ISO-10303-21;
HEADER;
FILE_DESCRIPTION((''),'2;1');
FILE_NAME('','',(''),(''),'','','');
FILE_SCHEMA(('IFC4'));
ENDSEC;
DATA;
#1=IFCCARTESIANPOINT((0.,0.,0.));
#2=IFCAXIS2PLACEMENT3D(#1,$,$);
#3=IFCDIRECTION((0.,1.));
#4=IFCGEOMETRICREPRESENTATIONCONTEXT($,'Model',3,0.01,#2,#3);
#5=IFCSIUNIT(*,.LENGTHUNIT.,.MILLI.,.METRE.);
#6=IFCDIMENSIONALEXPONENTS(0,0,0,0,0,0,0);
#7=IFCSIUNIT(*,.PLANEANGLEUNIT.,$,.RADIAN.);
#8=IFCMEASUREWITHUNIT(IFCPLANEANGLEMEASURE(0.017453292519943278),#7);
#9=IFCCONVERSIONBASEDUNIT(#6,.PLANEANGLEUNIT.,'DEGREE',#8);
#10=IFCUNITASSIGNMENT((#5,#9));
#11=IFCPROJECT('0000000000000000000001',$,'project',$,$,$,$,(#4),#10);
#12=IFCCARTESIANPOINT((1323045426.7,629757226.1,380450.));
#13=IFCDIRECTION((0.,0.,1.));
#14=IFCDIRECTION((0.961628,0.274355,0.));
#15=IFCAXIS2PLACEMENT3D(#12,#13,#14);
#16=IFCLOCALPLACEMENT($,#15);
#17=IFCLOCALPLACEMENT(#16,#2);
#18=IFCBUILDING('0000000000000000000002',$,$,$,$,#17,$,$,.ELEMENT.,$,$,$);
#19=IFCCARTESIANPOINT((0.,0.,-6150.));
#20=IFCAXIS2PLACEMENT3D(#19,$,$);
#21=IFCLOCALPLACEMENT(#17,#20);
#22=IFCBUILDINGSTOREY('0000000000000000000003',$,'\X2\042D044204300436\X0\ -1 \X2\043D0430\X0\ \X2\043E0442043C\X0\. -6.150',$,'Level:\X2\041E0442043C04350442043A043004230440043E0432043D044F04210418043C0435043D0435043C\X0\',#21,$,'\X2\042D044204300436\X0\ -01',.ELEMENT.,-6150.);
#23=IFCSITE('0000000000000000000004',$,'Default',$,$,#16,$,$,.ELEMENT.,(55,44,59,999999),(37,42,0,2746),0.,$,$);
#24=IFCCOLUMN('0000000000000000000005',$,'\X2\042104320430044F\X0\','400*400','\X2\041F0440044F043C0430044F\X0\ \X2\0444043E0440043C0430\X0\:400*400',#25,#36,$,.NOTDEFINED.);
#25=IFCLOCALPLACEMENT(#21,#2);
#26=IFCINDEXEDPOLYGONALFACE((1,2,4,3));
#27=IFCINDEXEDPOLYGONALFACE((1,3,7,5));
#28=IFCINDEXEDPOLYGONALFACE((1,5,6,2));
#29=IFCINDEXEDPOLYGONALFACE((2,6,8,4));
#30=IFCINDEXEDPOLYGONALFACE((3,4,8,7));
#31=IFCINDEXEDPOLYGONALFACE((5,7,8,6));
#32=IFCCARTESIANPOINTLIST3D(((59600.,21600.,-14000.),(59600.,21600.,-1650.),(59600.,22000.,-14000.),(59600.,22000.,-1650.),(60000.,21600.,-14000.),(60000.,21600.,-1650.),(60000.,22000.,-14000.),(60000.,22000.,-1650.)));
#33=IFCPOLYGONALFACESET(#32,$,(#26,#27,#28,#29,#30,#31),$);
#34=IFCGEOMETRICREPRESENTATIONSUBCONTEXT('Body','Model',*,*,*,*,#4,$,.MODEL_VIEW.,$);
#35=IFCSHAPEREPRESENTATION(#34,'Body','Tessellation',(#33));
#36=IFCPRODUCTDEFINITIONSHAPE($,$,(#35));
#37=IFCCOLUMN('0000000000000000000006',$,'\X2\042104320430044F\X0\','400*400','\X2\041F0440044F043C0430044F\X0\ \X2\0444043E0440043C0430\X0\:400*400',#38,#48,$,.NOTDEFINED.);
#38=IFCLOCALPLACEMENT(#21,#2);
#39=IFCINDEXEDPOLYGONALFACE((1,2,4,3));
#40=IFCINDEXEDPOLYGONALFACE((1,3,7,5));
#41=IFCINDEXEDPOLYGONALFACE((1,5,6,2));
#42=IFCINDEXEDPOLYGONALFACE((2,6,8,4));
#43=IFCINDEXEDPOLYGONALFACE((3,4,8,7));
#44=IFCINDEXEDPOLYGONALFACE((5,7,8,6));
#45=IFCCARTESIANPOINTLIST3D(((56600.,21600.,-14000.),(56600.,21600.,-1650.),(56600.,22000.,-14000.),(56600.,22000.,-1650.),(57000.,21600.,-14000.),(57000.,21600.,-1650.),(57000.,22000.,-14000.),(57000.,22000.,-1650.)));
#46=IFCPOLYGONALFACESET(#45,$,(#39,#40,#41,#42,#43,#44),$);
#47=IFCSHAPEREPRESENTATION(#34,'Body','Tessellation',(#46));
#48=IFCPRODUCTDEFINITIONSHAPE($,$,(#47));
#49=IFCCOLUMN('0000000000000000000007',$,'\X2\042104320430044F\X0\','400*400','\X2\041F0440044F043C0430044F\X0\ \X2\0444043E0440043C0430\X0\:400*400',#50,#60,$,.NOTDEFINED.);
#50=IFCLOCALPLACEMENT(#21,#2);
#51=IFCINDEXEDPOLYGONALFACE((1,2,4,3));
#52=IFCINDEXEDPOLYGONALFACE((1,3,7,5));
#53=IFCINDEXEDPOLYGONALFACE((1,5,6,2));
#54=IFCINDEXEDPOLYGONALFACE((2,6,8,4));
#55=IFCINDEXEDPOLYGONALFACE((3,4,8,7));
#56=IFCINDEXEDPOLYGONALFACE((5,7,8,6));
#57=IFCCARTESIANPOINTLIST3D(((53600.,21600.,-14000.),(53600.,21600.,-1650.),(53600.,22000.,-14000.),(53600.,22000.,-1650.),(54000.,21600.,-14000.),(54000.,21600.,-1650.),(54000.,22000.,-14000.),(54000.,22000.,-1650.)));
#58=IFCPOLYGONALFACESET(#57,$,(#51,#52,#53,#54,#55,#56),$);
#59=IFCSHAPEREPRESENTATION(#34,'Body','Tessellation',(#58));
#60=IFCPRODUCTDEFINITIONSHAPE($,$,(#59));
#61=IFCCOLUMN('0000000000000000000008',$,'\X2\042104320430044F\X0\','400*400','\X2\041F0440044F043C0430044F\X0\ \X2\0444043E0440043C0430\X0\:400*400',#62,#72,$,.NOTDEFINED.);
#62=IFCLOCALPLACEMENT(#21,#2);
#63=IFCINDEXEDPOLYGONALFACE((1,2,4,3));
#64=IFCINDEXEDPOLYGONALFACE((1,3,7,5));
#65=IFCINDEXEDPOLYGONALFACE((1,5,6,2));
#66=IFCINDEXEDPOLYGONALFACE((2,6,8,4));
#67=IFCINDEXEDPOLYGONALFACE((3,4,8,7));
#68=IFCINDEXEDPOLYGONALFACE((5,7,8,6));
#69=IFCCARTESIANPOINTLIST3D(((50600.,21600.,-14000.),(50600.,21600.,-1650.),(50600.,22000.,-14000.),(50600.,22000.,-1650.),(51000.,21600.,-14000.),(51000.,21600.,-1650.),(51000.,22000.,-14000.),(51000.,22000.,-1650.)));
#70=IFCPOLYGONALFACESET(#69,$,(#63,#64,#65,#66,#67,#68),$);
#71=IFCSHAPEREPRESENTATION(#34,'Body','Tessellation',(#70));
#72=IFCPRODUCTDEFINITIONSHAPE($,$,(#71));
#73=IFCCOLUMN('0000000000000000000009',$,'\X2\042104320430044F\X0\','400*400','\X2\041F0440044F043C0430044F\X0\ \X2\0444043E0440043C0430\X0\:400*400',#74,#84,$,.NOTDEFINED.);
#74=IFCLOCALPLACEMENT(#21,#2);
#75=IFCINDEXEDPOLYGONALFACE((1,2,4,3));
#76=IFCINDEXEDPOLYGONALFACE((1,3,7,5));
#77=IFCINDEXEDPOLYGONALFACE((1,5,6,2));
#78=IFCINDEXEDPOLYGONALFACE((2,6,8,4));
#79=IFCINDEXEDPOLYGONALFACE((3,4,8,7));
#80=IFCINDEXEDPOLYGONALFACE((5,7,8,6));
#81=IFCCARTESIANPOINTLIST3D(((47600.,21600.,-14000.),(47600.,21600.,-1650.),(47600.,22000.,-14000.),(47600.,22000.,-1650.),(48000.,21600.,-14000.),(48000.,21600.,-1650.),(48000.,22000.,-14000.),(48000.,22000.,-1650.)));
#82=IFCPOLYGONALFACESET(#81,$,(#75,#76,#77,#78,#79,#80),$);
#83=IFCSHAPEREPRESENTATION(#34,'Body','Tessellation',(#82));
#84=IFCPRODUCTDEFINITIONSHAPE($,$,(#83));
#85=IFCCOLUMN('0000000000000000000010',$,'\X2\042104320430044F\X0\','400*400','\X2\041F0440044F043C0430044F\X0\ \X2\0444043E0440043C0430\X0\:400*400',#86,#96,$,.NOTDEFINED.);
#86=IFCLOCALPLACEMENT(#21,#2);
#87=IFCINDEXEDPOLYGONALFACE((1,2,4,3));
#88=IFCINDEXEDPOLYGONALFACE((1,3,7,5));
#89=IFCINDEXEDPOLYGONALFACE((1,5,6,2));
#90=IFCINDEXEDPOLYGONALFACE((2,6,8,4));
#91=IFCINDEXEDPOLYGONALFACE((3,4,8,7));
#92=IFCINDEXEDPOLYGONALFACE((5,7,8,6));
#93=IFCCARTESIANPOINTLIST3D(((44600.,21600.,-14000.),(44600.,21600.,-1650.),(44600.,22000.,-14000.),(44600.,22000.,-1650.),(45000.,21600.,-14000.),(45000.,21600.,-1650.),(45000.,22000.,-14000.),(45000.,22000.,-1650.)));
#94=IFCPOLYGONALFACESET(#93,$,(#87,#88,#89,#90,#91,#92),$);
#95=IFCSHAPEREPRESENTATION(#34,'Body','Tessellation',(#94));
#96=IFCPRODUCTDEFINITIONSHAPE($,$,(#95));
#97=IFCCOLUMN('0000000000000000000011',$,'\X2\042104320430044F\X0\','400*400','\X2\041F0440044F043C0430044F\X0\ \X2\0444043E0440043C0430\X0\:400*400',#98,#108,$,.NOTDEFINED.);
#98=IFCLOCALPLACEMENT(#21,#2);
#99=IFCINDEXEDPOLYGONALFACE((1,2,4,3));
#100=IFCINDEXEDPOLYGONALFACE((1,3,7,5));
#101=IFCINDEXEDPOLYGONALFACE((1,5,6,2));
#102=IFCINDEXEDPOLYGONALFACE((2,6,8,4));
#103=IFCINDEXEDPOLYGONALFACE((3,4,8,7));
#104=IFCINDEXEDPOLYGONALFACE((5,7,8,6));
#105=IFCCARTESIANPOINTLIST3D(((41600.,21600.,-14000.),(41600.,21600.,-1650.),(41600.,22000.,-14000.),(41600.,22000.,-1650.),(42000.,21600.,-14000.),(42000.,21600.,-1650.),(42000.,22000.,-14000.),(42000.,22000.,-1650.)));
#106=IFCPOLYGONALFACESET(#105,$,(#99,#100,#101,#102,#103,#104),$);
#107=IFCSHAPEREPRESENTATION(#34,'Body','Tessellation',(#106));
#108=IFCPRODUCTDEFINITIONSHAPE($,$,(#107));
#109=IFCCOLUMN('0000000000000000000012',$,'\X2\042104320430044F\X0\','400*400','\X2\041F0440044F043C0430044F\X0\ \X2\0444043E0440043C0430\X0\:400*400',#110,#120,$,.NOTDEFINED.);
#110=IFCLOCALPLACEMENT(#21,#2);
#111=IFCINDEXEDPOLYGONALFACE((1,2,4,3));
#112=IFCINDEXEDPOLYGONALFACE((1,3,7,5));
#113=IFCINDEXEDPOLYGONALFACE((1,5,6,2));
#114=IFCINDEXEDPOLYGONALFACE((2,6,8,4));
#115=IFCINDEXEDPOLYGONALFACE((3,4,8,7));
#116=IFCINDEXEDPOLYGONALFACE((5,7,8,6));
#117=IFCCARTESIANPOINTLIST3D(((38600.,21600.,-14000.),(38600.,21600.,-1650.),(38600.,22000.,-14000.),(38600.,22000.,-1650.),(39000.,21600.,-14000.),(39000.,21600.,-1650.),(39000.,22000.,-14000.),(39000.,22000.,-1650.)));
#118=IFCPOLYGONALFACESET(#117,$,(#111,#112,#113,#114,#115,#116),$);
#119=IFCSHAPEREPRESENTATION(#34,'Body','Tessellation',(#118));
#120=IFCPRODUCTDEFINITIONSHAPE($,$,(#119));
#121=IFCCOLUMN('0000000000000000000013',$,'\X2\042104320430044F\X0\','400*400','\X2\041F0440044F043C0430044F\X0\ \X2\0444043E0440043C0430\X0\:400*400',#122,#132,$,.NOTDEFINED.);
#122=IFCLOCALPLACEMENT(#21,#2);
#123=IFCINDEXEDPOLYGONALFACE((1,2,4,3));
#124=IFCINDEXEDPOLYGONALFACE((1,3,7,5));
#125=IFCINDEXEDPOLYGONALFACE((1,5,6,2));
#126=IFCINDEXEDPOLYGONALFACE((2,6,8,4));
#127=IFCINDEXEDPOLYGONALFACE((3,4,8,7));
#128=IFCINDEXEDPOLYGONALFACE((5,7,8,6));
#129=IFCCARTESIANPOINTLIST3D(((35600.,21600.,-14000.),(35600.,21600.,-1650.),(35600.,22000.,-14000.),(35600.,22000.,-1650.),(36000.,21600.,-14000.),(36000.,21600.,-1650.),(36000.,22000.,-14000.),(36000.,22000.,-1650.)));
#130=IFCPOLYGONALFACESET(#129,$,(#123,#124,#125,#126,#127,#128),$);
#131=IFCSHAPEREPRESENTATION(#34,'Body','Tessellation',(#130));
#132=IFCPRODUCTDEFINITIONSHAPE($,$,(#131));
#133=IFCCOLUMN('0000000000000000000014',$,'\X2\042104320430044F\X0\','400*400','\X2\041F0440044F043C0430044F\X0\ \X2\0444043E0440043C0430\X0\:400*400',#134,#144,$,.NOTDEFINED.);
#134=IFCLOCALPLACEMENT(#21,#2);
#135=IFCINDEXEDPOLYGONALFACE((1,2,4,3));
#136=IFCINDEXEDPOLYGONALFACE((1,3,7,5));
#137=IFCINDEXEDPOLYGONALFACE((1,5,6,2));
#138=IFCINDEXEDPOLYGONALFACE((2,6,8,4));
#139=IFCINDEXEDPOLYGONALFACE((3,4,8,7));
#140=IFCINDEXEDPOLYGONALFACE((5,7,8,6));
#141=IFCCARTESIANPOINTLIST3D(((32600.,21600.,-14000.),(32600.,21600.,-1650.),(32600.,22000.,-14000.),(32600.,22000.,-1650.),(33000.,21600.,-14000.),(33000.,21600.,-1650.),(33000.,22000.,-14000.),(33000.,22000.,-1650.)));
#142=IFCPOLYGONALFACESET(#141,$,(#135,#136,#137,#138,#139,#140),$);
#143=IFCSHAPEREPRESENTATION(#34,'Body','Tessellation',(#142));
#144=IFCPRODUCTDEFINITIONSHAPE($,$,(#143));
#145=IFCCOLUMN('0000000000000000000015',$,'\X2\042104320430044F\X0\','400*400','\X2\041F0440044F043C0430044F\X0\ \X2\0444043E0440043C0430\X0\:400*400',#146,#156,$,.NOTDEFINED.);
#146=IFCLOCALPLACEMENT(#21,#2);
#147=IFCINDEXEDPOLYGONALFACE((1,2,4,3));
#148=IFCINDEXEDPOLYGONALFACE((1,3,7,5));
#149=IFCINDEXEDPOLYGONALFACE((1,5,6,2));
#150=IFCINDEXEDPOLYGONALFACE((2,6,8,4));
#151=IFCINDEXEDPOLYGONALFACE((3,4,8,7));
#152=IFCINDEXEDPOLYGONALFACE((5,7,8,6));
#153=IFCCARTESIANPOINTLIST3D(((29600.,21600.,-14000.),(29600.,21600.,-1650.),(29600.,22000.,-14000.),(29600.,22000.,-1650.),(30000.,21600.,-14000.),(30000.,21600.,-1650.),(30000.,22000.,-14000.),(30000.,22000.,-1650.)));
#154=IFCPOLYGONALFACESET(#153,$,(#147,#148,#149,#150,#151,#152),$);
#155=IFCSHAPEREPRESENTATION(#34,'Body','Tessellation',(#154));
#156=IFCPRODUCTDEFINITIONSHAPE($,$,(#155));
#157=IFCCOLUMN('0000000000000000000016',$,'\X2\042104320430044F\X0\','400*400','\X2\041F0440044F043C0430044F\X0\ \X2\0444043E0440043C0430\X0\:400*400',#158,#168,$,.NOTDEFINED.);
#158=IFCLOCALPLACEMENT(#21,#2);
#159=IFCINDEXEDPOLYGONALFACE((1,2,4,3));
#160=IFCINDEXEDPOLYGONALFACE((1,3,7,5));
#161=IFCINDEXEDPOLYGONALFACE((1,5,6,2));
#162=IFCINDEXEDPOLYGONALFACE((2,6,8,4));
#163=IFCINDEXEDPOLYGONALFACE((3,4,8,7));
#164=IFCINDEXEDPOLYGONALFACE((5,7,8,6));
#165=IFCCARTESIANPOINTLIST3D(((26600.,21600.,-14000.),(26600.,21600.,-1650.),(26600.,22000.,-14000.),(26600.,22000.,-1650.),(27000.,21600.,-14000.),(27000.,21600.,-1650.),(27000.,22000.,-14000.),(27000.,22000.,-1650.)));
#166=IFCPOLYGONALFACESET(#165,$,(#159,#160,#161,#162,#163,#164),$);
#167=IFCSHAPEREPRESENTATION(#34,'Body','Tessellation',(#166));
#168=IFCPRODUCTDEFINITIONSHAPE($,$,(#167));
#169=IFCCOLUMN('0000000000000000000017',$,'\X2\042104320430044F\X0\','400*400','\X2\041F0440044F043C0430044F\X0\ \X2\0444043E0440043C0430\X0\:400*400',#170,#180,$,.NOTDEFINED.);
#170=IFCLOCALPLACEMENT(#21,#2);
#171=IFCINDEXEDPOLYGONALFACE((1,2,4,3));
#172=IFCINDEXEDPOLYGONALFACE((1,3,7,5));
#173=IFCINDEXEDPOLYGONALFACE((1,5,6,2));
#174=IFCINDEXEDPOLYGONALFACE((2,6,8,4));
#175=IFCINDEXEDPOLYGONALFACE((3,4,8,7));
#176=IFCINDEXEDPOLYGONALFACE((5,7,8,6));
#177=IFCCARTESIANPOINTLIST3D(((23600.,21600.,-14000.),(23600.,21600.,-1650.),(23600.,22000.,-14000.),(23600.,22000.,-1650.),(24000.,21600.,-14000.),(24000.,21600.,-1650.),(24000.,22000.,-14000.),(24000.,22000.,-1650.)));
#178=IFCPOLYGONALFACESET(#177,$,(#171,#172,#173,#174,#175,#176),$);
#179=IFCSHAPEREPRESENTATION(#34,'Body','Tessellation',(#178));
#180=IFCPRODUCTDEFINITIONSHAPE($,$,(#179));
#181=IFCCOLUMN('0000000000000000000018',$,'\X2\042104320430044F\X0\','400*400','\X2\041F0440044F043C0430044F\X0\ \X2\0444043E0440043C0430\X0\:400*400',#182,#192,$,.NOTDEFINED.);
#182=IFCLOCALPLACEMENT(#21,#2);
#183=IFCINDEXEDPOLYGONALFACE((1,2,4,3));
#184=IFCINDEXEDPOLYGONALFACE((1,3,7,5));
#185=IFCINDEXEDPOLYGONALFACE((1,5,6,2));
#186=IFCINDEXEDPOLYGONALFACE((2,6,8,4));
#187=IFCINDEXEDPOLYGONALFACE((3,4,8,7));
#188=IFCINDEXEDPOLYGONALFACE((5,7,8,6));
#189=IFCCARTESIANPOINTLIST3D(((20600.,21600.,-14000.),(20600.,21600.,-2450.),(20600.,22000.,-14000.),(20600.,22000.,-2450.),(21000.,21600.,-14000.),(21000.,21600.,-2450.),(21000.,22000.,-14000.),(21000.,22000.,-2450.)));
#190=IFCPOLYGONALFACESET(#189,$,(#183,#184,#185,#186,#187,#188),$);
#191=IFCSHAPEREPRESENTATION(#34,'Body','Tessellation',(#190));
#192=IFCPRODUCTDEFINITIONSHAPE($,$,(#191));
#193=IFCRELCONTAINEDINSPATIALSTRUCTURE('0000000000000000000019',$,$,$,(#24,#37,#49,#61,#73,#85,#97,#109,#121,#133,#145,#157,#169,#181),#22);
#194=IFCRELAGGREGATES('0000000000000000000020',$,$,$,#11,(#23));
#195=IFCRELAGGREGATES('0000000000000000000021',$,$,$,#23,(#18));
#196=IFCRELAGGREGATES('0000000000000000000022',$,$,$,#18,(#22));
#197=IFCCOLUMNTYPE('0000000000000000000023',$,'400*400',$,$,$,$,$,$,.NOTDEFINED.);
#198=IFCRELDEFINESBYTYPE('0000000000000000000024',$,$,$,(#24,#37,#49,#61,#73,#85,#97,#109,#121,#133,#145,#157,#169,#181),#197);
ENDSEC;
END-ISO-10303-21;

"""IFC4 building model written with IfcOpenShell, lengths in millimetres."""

from ifc_helpers import new_model, entity, si_unit, converted_unit, direction, frame, origin, place, context, subcontext, project, spatial, indexed_curve, outline, extrude, type_object, element, save


model = new_model("IFC4")

# Units and contexts
model_context = context("Model", 3, precision=0.01, world=origin(), true_north=direction((0.0, 1.0)))
body_context = subcontext(model_context, "Body", "Model", "MODEL_VIEW")
ifc_project = project(units=[si_unit("LENGTHUNIT", "METRE", prefix="MILLI"), converted_unit("PLANEANGLEUNIT", "DEGREE", entity("IfcPlaneAngleMeasure", 0.017453292519943278), si_unit("PLANEANGLEUNIT", "RADIAN"), dimensions=[0, 0, 0, 0, 0, 0, 0])], contexts=[model_context])

# Site, building, storey
site_placement = place(None, frame((1323045426.7, 629757226.1, 380450.0), z_axis=(0.0, 0.0, 1.0), x_axis=(0.961628, 0.274355, 0.0)))
site = spatial("IfcSite", under=ifc_project, at=site_placement, Name="Default", CompositionType="ELEMENT", RefLatitude=(55, 44, 59, 999999), RefLongitude=(37, 42, 0, 2746), RefElevation=0.0)
building_placement = place(site_placement, origin())
building = spatial("IfcBuilding", under=site, at=building_placement, CompositionType="ELEMENT")
storey_placement = place(building_placement, frame((0.0, 0.0, -6150.0)))
storey = spatial("IfcBuildingStorey", under=building, at=storey_placement, Name="Этаж -1 на отм. -6.150", ObjectType="Level:ОтметкаУровняСИменем", LongName="Этаж -01", CompositionType="ELEMENT", Elevation=-6150.0)

# Columns
column_type = type_object("IfcColumnType", Name="400*400", PredefinedType="NOTDEFINED")
column_1_placement = place(storey_placement, origin())
element("IfcColumn", 1, at=column_1_placement, inside=storey, type_object=column_type, Name="Свая", Description="400*400", ObjectType="Прямая форма:400*400", PredefinedType="NOTDEFINED", context=body_context, shape_type="SweptSolid", body=[
    extrude(outline(indexed_curve([(-200.0, -200.0), (200.0, -200.0), (200.0, 200.0), (-200.0, 200.0), (-200.0, -200.0)], self_intersect=False)), frame((59800.0, 21800.0, -14000.0), z_axis=(0.0, 0.0, 1.0), x_axis=(0.0, 1.0, 0.0)), (0.0, 0.0, 1.0), 12350.0),
])
column_2_placement = place(storey_placement, origin())
element("IfcColumn", 2, at=column_2_placement, inside=storey, type_object=column_type, Name="Свая", Description="400*400", ObjectType="Прямая форма:400*400", PredefinedType="NOTDEFINED", context=body_context, shape_type="SweptSolid", body=[
    extrude(outline(indexed_curve([(-200.0, -200.0), (200.0, -200.0), (200.0, 200.0), (-200.0, 200.0), (-200.0, -200.0)], self_intersect=False)), frame((56800.0, 21800.0, -14000.0), z_axis=(0.0, 0.0, 1.0), x_axis=(0.0, 1.0, 0.0)), (0.0, 0.0, 1.0), 12350.0),
])
column_3_placement = place(storey_placement, origin())
element("IfcColumn", 3, at=column_3_placement, inside=storey, type_object=column_type, Name="Свая", Description="400*400", ObjectType="Прямая форма:400*400", PredefinedType="NOTDEFINED", context=body_context, shape_type="SweptSolid", body=[
    extrude(outline(indexed_curve([(-200.0, -200.0), (200.0, -200.0), (200.0, 200.0), (-200.0, 200.0), (-200.0, -200.0)], self_intersect=False)), frame((53800.0, 21800.0, -14000.0), z_axis=(0.0, 0.0, 1.0), x_axis=(0.0, 1.0, 0.0)), (0.0, 0.0, 1.0), 12350.0),
])
column_4_placement = place(storey_placement, origin())
element("IfcColumn", 4, at=column_4_placement, inside=storey, type_object=column_type, Name="Свая", Description="400*400", ObjectType="Прямая форма:400*400", PredefinedType="NOTDEFINED", context=body_context, shape_type="SweptSolid", body=[
    extrude(outline(indexed_curve([(-200.0, -200.0), (200.0, -200.0), (200.0, 200.0), (-200.0, 200.0), (-200.0, -200.0)], self_intersect=False)), frame((50800.0, 21800.0, -14000.0), z_axis=(0.0, 0.0, 1.0), x_axis=(0.0, 1.0, 0.0)), (0.0, 0.0, 1.0), 12350.0),
])
column_5_placement = place(storey_placement, origin())
element("IfcColumn", 5, at=column_5_placement, inside=storey, type_object=column_type, Name="Свая", Description="400*400", ObjectType="Прямая форма:400*400", PredefinedType="NOTDEFINED", context=body_context, shape_type="SweptSolid", body=[
    extrude(outline(indexed_curve([(-200.0, -200.0), (200.0, -200.0), (200.0, 200.0), (-200.0, 200.0), (-200.0, -200.0)], self_intersect=False)), frame((47800.0, 21800.0, -14000.0), z_axis=(0.0, 0.0, 1.0), x_axis=(0.0, 1.0, 0.0)), (0.0, 0.0, 1.0), 12350.0),
])
column_6_placement = place(storey_placement, origin())
element("IfcColumn", 6, at=column_6_placement, inside=storey, type_object=column_type, Name="Свая", Description="400*400", ObjectType="Прямая форма:400*400", PredefinedType="NOTDEFINED", context=body_context, shape_type="SweptSolid", body=[
    extrude(outline(indexed_curve([(-200.0, -200.0), (200.0, -200.0), (200.0, 200.0), (-200.0, 200.0), (-200.0, -200.0)], self_intersect=False)), frame((44800.0, 21800.0, -14000.0), z_axis=(0.0, 0.0, 1.0), x_axis=(0.0, 1.0, 0.0)), (0.0, 0.0, 1.0), 12350.0),
])
column_7_placement = place(storey_placement, origin())
element("IfcColumn", 7, at=column_7_placement, inside=storey, type_object=column_type, Name="Свая", Description="400*400", ObjectType="Прямая форма:400*400", PredefinedType="NOTDEFINED", context=body_context, shape_type="SweptSolid", body=[
    extrude(outline(indexed_curve([(-200.0, -200.0), (200.0, -200.0), (200.0, 200.0), (-200.0, 200.0), (-200.0, -200.0)], self_intersect=False)), frame((41800.0, 21800.0, -14000.0), z_axis=(0.0, 0.0, 1.0), x_axis=(0.0, 1.0, 0.0)), (0.0, 0.0, 1.0), 12350.0),
])
column_8_placement = place(storey_placement, origin())
element("IfcColumn", 8, at=column_8_placement, inside=storey, type_object=column_type, Name="Свая", Description="400*400", ObjectType="Прямая форма:400*400", PredefinedType="NOTDEFINED", context=body_context, shape_type="SweptSolid", body=[
    extrude(outline(indexed_curve([(-200.0, -200.0), (200.0, -200.0), (200.0, 200.0), (-200.0, 200.0), (-200.0, -200.0)], self_intersect=False)), frame((38800.0, 21800.0, -14000.0), z_axis=(0.0, 0.0, 1.0), x_axis=(0.0, 1.0, 0.0)), (0.0, 0.0, 1.0), 12350.0),
])
column_9_placement = place(storey_placement, origin())
element("IfcColumn", 9, at=column_9_placement, inside=storey, type_object=column_type, Name="Свая", Description="400*400", ObjectType="Прямая форма:400*400", PredefinedType="NOTDEFINED", context=body_context, shape_type="SweptSolid", body=[
    extrude(outline(indexed_curve([(-200.0, -200.0), (200.0, -200.0), (200.0, 200.0), (-200.0, 200.0), (-200.0, -200.0)], self_intersect=False)), frame((35800.0, 21800.0, -14000.0), z_axis=(0.0, 0.0, 1.0), x_axis=(0.0, 1.0, 0.0)), (0.0, 0.0, 1.0), 12350.0),
])
column_10_placement = place(storey_placement, origin())
element("IfcColumn", 10, at=column_10_placement, inside=storey, type_object=column_type, Name="Свая", Description="400*400", ObjectType="Прямая форма:400*400", PredefinedType="NOTDEFINED", context=body_context, shape_type="SweptSolid", body=[
    extrude(outline(indexed_curve([(-200.0, -200.0), (200.0, -200.0), (200.0, 200.0), (-200.0, 200.0), (-200.0, -200.0)], self_intersect=False)), frame((32800.0, 21800.0, -14000.0), z_axis=(0.0, 0.0, 1.0), x_axis=(0.0, 1.0, 0.0)), (0.0, 0.0, 1.0), 12350.0),
])
column_11_placement = place(storey_placement, origin())
element("IfcColumn", 11, at=column_11_placement, inside=storey, type_object=column_type, Name="Свая", Description="400*400", ObjectType="Прямая форма:400*400", PredefinedType="NOTDEFINED", context=body_context, shape_type="SweptSolid", body=[
    extrude(outline(indexed_curve([(-200.0, -200.0), (200.0, -200.0), (200.0, 200.0), (-200.0, 200.0), (-200.0, -200.0)], self_intersect=False)), frame((29800.0, 21800.0, -14000.0), z_axis=(0.0, 0.0, 1.0), x_axis=(0.0, 1.0, 0.0)), (0.0, 0.0, 1.0), 12350.0),
])
column_12_placement = place(storey_placement, origin())
element("IfcColumn", 12, at=column_12_placement, inside=storey, type_object=column_type, Name="Свая", Description="400*400", ObjectType="Прямая форма:400*400", PredefinedType="NOTDEFINED", context=body_context, shape_type="SweptSolid", body=[
    extrude(outline(indexed_curve([(-200.0, -200.0), (200.0, -200.0), (200.0, 200.0), (-200.0, 200.0), (-200.0, -200.0)], self_intersect=False)), frame((26800.0, 21800.0, -14000.0), z_axis=(0.0, 0.0, 1.0), x_axis=(0.0, 1.0, 0.0)), (0.0, 0.0, 1.0), 12350.0),
])
column_13_placement = place(storey_placement, origin())
element("IfcColumn", 13, at=column_13_placement, inside=storey, type_object=column_type, Name="Свая", Description="400*400", ObjectType="Прямая форма:400*400", PredefinedType="NOTDEFINED", context=body_context, shape_type="SweptSolid", body=[
    extrude(outline(indexed_curve([(-200.0, -200.0), (200.0, -200.0), (200.0, 200.0), (-200.0, 200.0), (-200.0, -200.0)], self_intersect=False)), frame((23800.0, 21800.0, -14000.0), z_axis=(0.0, 0.0, 1.0), x_axis=(0.0, 1.0, 0.0)), (0.0, 0.0, 1.0), 12350.0),
])
column_14_placement = place(storey_placement, origin())
element("IfcColumn", 14, at=column_14_placement, inside=storey, type_object=column_type, Name="Свая", Description="400*400", ObjectType="Прямая форма:400*400", PredefinedType="NOTDEFINED", context=body_context, shape_type="SweptSolid", body=[
    extrude(outline(indexed_curve([(-200.0, -200.0), (200.0, -200.0), (200.0, 200.0), (-200.0, 200.0), (-200.0, -200.0)], self_intersect=False)), frame((20800.0, 21800.0, -14000.0), z_axis=(0.0, 0.0, 1.0), x_axis=(0.0, 1.0, 0.0)), (0.0, 0.0, 1.0), 11550.0),
])

save(model, "model.ifc")
